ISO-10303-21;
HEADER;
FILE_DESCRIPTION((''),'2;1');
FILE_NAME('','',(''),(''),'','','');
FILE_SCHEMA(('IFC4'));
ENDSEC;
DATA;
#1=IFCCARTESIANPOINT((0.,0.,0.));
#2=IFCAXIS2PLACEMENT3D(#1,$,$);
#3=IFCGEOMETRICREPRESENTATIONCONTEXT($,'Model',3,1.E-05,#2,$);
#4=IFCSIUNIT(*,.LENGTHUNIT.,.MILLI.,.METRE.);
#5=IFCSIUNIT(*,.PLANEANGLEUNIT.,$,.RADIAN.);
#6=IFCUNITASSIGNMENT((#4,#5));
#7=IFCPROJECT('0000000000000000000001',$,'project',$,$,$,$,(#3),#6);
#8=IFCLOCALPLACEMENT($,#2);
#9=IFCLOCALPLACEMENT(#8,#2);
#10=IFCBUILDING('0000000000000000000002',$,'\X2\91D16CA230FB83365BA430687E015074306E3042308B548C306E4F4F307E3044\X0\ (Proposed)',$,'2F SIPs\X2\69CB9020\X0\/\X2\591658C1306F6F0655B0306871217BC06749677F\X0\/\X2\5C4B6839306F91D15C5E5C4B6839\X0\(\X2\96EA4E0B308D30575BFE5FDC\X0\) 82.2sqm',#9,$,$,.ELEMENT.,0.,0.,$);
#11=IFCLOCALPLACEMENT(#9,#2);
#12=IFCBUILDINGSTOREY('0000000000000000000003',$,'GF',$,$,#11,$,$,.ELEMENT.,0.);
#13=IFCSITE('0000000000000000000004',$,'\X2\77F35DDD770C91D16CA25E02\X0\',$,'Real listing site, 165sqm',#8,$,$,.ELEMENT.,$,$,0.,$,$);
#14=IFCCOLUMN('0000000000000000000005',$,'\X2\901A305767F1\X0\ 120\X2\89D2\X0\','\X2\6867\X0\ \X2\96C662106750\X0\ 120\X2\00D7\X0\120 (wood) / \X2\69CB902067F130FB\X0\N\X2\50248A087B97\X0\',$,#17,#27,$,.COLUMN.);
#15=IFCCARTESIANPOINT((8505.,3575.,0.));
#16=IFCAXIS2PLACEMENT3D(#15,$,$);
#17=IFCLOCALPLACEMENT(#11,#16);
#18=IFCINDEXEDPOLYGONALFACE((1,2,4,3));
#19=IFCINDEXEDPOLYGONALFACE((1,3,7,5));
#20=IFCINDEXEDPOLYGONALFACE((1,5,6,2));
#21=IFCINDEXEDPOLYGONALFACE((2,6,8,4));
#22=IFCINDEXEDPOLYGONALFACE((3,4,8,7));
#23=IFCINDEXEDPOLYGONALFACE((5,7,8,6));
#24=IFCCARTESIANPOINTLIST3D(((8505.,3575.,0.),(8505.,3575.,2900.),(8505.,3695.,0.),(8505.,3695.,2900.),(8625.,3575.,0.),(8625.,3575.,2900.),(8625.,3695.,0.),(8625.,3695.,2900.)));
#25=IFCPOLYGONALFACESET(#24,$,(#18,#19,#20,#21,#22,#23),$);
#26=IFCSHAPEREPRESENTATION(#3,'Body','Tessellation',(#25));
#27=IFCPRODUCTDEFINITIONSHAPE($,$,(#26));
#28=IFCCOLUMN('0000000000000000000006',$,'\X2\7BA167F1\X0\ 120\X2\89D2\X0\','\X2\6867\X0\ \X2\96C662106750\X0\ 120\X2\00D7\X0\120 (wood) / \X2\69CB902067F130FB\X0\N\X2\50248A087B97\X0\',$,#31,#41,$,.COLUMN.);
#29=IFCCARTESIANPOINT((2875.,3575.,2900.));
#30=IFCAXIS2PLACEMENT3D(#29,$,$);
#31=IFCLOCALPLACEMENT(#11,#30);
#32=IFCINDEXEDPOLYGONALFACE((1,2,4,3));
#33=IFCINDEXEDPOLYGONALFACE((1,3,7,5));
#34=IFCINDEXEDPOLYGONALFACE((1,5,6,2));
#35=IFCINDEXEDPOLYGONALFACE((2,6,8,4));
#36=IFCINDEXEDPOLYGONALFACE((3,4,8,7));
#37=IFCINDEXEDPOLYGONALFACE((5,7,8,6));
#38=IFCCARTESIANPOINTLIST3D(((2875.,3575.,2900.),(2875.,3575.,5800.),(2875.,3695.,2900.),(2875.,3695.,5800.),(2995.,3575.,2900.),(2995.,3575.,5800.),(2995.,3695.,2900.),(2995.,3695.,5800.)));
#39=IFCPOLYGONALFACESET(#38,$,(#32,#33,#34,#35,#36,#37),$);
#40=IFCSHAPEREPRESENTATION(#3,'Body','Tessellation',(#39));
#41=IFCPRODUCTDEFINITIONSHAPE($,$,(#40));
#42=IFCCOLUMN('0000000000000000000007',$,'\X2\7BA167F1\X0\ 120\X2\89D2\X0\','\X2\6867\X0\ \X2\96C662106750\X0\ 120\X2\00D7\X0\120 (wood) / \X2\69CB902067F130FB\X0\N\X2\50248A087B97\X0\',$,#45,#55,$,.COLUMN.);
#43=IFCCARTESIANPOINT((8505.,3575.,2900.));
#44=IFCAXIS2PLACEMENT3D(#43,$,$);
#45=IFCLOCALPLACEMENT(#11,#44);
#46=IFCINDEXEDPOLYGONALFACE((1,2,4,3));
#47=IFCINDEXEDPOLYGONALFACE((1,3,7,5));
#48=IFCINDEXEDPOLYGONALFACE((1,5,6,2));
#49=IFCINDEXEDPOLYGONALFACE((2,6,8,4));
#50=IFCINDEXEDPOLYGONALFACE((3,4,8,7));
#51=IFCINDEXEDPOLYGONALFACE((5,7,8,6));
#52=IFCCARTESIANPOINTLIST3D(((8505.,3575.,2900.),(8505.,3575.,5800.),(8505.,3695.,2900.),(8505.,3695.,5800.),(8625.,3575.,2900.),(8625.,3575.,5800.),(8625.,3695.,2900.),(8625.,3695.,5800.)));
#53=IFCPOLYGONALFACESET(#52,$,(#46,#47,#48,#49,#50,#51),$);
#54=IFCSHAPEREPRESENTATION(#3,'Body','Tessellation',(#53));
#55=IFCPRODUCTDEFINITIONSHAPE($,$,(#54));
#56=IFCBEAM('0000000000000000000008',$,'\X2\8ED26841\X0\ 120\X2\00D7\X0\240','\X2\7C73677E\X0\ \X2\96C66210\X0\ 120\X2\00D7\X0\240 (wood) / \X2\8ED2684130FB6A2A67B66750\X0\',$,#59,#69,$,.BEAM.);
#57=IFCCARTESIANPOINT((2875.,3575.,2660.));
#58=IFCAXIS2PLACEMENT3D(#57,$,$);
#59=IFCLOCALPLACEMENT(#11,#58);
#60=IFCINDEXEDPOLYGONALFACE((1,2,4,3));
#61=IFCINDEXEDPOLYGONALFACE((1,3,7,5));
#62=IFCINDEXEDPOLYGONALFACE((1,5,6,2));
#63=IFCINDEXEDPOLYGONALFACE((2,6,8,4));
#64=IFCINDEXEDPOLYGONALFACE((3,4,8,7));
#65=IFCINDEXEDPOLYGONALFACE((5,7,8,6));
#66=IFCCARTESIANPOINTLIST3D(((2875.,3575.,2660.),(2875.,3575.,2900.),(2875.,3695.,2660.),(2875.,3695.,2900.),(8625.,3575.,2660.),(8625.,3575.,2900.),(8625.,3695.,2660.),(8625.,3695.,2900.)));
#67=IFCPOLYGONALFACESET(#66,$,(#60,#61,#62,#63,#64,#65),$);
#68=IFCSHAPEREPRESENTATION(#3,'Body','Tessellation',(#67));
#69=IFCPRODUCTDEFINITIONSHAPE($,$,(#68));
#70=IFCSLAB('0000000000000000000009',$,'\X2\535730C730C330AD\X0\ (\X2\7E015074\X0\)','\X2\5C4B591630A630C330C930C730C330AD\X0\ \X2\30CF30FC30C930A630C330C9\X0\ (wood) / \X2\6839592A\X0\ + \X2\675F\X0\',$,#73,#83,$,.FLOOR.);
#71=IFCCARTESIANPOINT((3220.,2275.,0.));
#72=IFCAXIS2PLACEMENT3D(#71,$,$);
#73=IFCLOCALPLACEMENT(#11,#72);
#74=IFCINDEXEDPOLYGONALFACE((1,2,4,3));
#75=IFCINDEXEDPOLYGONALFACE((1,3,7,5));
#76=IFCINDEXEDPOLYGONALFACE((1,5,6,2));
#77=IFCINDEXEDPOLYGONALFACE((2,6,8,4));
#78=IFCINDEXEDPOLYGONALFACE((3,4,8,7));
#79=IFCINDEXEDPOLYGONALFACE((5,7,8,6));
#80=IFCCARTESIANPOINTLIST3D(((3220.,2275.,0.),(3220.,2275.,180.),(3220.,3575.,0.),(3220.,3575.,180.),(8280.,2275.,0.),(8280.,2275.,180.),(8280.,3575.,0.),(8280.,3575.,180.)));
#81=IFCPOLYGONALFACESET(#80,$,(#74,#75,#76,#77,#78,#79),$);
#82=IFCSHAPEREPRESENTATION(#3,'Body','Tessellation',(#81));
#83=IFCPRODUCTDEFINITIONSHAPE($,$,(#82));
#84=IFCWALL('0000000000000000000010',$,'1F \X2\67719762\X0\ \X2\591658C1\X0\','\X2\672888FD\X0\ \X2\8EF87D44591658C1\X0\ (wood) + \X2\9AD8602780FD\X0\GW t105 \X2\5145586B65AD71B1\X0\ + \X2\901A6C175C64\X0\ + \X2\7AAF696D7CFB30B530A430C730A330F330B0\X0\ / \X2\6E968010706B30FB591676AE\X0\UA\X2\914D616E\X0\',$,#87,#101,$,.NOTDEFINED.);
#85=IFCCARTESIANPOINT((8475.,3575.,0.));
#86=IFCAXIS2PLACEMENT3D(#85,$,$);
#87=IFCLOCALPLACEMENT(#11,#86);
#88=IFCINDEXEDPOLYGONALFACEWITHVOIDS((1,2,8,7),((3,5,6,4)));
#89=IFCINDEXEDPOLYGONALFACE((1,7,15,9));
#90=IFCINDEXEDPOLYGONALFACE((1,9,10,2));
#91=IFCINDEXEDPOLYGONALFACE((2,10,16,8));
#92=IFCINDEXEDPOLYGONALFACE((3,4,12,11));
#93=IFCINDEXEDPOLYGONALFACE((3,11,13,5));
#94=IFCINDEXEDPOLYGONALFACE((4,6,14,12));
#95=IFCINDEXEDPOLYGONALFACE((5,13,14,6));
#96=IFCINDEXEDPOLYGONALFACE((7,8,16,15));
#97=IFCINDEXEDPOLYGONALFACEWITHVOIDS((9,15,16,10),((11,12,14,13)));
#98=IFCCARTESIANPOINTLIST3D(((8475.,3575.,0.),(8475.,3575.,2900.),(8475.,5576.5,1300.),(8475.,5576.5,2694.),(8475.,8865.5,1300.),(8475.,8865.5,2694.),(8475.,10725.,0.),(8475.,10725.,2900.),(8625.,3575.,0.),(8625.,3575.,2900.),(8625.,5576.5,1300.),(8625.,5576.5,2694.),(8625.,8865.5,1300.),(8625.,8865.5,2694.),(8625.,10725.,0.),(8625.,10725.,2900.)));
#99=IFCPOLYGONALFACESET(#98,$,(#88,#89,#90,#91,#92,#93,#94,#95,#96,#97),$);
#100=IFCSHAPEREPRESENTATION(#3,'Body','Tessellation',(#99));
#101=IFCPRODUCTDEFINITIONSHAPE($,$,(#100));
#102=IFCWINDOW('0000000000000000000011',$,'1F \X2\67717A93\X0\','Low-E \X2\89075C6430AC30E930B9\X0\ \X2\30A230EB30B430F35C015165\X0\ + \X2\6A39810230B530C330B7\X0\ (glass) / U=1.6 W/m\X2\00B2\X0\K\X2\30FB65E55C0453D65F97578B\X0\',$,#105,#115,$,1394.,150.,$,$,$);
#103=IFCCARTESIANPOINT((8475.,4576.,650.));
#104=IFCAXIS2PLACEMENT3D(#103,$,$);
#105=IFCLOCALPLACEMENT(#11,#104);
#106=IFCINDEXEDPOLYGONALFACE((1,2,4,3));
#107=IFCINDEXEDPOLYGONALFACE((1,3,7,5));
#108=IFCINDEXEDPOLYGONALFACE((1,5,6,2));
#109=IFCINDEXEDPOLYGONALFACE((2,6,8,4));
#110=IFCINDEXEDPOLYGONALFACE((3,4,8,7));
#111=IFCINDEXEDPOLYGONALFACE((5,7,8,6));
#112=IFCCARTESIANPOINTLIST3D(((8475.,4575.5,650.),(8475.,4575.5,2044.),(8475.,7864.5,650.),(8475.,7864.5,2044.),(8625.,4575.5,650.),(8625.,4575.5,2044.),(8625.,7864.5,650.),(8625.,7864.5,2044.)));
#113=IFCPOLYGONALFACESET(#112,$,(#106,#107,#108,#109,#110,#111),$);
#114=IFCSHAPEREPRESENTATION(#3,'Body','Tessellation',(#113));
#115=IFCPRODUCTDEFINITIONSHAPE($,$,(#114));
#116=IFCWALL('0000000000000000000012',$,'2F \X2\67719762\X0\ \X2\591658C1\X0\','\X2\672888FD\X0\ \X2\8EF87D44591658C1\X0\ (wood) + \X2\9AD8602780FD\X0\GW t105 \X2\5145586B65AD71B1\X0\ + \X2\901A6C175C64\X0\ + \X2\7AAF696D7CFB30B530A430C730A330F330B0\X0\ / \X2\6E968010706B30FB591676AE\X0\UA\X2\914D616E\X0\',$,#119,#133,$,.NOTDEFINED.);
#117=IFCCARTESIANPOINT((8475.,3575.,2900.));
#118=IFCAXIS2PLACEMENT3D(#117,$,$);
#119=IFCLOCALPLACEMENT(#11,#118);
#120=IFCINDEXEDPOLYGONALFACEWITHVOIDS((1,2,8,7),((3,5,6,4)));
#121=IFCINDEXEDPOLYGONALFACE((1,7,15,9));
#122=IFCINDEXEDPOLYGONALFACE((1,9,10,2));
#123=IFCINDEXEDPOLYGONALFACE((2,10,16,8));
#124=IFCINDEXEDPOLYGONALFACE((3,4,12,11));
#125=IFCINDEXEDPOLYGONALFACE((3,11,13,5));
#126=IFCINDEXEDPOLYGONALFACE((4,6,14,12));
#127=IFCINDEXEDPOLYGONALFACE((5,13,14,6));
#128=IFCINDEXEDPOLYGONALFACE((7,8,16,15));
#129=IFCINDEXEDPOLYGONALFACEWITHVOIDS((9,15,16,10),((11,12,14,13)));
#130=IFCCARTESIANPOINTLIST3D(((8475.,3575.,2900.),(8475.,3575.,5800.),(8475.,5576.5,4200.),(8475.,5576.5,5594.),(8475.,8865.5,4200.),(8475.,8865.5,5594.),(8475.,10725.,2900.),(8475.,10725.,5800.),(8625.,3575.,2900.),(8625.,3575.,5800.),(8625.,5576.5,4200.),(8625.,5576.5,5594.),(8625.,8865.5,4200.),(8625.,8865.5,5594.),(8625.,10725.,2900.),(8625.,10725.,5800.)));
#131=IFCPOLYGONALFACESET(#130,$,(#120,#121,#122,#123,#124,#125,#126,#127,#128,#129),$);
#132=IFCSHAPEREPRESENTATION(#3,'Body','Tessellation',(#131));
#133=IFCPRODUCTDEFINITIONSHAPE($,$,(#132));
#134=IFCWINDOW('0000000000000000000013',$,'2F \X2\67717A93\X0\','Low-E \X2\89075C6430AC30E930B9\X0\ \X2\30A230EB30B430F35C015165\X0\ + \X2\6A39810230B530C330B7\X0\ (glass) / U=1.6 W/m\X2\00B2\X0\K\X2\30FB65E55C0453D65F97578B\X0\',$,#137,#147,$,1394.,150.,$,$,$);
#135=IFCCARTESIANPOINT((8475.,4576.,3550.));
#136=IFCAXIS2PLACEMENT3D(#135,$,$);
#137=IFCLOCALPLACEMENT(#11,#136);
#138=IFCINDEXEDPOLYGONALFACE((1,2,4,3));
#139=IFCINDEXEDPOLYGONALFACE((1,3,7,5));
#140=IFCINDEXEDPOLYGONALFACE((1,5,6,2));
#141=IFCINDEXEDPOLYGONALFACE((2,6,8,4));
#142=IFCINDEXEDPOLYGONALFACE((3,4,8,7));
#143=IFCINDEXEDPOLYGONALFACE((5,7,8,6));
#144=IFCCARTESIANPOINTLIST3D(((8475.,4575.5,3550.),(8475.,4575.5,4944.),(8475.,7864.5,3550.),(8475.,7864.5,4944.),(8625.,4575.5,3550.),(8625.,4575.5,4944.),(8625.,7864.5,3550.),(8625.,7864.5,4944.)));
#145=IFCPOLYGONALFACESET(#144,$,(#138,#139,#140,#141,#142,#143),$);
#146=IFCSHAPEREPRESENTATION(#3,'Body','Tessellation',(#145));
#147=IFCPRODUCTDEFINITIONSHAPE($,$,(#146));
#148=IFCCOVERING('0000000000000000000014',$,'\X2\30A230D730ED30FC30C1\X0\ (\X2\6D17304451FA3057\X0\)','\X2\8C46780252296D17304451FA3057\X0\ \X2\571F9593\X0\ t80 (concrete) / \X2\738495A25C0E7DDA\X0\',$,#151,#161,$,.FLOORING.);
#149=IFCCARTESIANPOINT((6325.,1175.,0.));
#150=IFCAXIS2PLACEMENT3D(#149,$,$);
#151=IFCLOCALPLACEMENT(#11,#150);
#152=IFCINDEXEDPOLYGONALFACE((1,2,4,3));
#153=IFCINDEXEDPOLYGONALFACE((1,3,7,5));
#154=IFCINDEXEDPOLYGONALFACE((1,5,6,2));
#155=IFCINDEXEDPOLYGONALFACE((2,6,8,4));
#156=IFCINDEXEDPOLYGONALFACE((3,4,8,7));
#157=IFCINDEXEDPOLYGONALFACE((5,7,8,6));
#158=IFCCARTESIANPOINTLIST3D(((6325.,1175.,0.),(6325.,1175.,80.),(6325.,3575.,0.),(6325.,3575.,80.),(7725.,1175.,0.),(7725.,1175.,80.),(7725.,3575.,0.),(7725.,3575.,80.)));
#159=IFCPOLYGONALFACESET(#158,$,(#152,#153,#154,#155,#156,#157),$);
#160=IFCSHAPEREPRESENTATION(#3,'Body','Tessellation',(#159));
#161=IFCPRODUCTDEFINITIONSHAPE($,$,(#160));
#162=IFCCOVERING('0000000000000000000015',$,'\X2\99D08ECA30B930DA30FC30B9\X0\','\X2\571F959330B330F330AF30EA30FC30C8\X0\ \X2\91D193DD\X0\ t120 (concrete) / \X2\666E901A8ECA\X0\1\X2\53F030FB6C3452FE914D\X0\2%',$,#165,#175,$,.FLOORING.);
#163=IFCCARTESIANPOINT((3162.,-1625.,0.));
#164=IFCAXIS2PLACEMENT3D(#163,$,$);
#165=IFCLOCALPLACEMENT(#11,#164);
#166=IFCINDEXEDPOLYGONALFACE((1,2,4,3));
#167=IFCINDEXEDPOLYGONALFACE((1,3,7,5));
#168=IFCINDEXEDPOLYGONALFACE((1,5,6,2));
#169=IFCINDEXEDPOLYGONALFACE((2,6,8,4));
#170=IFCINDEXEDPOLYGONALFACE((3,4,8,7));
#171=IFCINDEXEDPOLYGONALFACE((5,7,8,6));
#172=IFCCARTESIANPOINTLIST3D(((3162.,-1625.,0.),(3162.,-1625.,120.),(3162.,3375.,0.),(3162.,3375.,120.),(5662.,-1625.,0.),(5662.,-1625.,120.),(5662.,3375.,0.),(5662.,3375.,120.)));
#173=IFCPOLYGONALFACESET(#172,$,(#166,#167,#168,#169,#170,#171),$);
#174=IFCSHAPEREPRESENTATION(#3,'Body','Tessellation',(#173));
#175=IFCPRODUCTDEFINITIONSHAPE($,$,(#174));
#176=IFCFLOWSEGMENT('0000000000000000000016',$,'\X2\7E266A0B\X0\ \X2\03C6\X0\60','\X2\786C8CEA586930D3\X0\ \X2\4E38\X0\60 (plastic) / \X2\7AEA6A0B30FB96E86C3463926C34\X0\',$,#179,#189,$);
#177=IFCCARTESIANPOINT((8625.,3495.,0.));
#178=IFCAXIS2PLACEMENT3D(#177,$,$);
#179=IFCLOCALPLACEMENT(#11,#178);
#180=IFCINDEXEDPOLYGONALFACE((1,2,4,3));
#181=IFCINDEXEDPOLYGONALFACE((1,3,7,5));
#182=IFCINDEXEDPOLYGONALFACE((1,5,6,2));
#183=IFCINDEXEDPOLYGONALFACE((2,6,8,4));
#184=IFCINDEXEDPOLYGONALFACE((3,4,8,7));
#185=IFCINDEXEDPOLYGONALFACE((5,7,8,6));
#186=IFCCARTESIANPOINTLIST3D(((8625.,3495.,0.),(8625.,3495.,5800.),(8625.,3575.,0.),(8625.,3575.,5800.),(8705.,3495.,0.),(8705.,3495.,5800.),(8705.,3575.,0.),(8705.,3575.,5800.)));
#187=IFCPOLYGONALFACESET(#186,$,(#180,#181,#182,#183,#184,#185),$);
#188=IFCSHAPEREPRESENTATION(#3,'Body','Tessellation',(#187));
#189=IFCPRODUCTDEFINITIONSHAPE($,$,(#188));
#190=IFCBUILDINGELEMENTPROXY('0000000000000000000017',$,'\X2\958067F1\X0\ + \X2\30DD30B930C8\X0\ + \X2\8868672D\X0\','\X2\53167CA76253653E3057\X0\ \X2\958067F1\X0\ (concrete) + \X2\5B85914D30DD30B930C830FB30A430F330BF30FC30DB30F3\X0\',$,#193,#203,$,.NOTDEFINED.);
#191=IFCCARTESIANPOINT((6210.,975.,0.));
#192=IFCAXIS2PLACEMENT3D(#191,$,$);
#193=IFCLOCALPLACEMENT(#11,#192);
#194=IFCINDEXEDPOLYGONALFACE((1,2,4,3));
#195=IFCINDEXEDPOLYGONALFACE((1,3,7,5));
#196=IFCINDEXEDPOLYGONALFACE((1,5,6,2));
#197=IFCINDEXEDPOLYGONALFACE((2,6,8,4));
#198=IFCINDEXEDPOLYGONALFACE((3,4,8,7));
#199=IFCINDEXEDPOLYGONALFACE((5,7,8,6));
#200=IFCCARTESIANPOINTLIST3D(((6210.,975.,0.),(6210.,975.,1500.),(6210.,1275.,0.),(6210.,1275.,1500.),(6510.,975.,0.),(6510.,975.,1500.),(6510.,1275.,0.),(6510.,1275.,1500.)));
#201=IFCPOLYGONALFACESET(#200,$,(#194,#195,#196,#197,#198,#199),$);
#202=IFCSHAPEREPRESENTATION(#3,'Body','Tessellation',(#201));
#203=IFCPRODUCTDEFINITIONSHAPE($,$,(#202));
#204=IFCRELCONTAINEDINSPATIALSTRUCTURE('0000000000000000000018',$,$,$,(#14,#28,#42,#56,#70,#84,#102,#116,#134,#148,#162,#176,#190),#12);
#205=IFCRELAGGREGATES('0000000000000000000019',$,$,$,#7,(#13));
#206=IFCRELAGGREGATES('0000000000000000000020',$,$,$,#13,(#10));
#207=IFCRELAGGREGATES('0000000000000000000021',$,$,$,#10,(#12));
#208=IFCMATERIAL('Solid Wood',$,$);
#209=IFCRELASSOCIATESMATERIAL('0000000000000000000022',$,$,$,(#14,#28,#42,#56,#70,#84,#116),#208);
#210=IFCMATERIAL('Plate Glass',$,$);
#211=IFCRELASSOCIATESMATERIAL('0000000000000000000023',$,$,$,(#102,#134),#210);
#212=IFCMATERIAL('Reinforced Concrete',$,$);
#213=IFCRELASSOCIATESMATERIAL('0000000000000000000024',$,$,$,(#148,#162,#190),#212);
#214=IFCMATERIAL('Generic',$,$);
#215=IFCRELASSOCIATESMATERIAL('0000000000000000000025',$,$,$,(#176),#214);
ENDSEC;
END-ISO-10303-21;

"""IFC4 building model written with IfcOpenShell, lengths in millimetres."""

from ifc_helpers import new_model, si_unit, frame, frame_2d, origin, place, context, project, spatial, rectangle, extrude, material, element, fill, save


model = new_model("IFC4")

# Units and contexts
model_context = context("Model", 3, precision=1e-05, world=origin())
ifc_project = project(units=[si_unit("LENGTHUNIT", "METRE", prefix="MILLI"), si_unit("PLANEANGLEUNIT", "RADIAN")], contexts=[model_context])

# Site, building, storey
site_placement = place(None, origin())
site = spatial("IfcSite", under=ifc_project, at=site_placement, Name="石川県金沢市", ObjectType="Real listing site, 165sqm", CompositionType="ELEMENT", RefElevation=0.0)
building_placement = place(site_placement, origin())
building = spatial("IfcBuilding", under=site, at=building_placement, Name="金沢・茶室と縁側のある和の住まい (Proposed)", ObjectType="2F SIPs構造/外壁は漆喰と無節杉板/屋根は金属屋根(雪下ろし対応) 82.2sqm", CompositionType="ELEMENT", ElevationOfRefHeight=0.0, ElevationOfTerrain=0.0)
storey_placement = place(building_placement, origin())
storey = spatial("IfcBuildingStorey", under=building, at=storey_placement, Name="GF", CompositionType="ELEMENT", Elevation=0.0)

# Columns
ifc_material_1 = material(Name="Solid Wood")
column_1_placement = place(storey_placement, frame((8505.0, 3575.0, 0.0)))
element("IfcColumn", 1, at=column_1_placement, inside=storey, material=ifc_material_1, Name="通し柱 120角", Description="桧 集成材 120×120 (wood) / 構造柱・N値計算", PredefinedType="COLUMN", context=model_context, shape_type="SweptSolid", body=[
    extrude(rectangle(XDim=120.0, YDim=120.0, at=frame_2d((60.0, 60.0))), frame((8505.0, 3575.0, 0.0)), (0.0, 0.0, 1.0), 2900.0),
])
column_2_placement = place(storey_placement, frame((2875.0, 3575.0, 2900.0)))
element("IfcColumn", 2, at=column_2_placement, inside=storey, material=ifc_material_1, Name="管柱 120角", Description="桧 集成材 120×120 (wood) / 構造柱・N値計算", PredefinedType="COLUMN", context=model_context, shape_type="SweptSolid", body=[
    extrude(rectangle(XDim=120.0, YDim=120.0, at=frame_2d((60.0, 60.0))), frame((2875.0, 3575.0, 2900.0)), (0.0, 0.0, 1.0), 2900.0),
])
column_3_placement = place(storey_placement, frame((8505.0, 3575.0, 2900.0)))
element("IfcColumn", 3, at=column_3_placement, inside=storey, material=ifc_material_1, Name="管柱 120角", Description="桧 集成材 120×120 (wood) / 構造柱・N値計算", PredefinedType="COLUMN", context=model_context, shape_type="SweptSolid", body=[
    extrude(rectangle(XDim=120.0, YDim=120.0, at=frame_2d((60.0, 60.0))), frame((8505.0, 3575.0, 2900.0)), (0.0, 0.0, 1.0), 2900.0),
])

# Beam
beam_1_placement = place(storey_placement, frame((2875.0, 3575.0, 2660.0)))
element("IfcBeam", 4, at=beam_1_placement, inside=storey, material=ifc_material_1, Name="軒桁 120×240", Description="米松 集成 120×240 (wood) / 軒桁・横架材", PredefinedType="BEAM", context=model_context, shape_type="SweptSolid", body=[
    extrude(rectangle(XDim=5750.0, YDim=120.0, at=frame_2d((2875.0, 60.0))), frame((2875.0, 3575.0, 2660.0)), (0.0, 0.0, 1.0), 240.0),
])

# Slab
slab_placement = place(storey_placement, frame((3220.0, 2275.0, 0.0)))
element("IfcSlab", 5, at=slab_placement, inside=storey, material=ifc_material_1, Name="南デッキ (縁側)", Description="屋外ウッドデッキ ハードウッド (wood) / 根太 + 束", PredefinedType="FLOOR", context=model_context, shape_type="SweptSolid", body=[
    extrude(rectangle(XDim=5060.0, YDim=1300.0, at=frame_2d((2530.0, 650.0))), frame((3220.0, 2275.0, 0.0)), (0.0, 0.0, 1.0), 180.0),
])

# Walls, openings, windows
wall_1_placement = place(storey_placement, frame((8475.0, 3575.0, 0.0)))
wall_1 = element("IfcWall", 6, at=wall_1_placement, inside=storey, material=ifc_material_1, Name="1F 東面 外壁", Description="木製 軸組外壁 (wood) + 高性能GW t105 充填断熱 + 通気層 + 窯業系サイディング / 準耐火・外皮UA配慮", PredefinedType="NOTDEFINED", context=model_context, shape_type="SweptSolid", body=[
    extrude(rectangle(XDim=150.0, YDim=7150.0, at=frame_2d((75.0, 3575.0))), frame((8475.0, 3575.0, 0.0)), (0.0, 0.0, 1.0), 2900.0),
])
opening_1_placement = place(storey_placement, frame((8475.0, 4576.0, 650.0)))
opening_1 = element("IfcOpeningElement", 7, at=opening_1_placement, cuts=wall_1, PredefinedType="NOTDEFINED", context=model_context, shape_type="SweptSolid", body=[
    extrude(rectangle(XDim=150.0, YDim=3289.0, at=frame_2d((75.0, 1644.0))), frame((8475.0, 4576.0, 650.0)), (0.0, 0.0, 1.0), 1394.0),
])
ifc_material_2 = material(Name="Plate Glass")
window_1_placement = place(storey_placement, frame((8475.0, 4576.0, 650.0)))
window_1 = element("IfcWindow", 8, at=window_1_placement, inside=storey, material=ifc_material_2, Name="1F 東窓", Description="Low-E 複層ガラス アルゴン封入 + 樹脂サッシ (glass) / U=1.6 W/m²K・日射取得型", OverallHeight=1394.0, OverallWidth=150.0, context=model_context, shape_type="SweptSolid", body=[
    extrude(rectangle(XDim=150.0, YDim=3289.0, at=frame_2d((75.0, 1644.0))), frame((8475.0, 4576.0, 650.0)), (0.0, 0.0, 1.0), 1394.0),
])
fill(opening_1, window_1)
wall_2_placement = place(storey_placement, frame((8475.0, 3575.0, 2900.0)))
wall_2 = element("IfcWall", 9, at=wall_2_placement, inside=storey, material=ifc_material_1, Name="2F 東面 外壁", Description="木製 軸組外壁 (wood) + 高性能GW t105 充填断熱 + 通気層 + 窯業系サイディング / 準耐火・外皮UA配慮", PredefinedType="NOTDEFINED", context=model_context, shape_type="SweptSolid", body=[
    extrude(rectangle(XDim=150.0, YDim=7150.0, at=frame_2d((75.0, 3575.0))), frame((8475.0, 3575.0, 2900.0)), (0.0, 0.0, 1.0), 2900.0),
])
opening_2_placement = place(storey_placement, frame((8475.0, 4576.0, 3550.0)))
opening_2 = element("IfcOpeningElement", 10, at=opening_2_placement, cuts=wall_2, PredefinedType="NOTDEFINED", context=model_context, shape_type="SweptSolid", body=[
    extrude(rectangle(XDim=150.0, YDim=3289.0, at=frame_2d((75.0, 1644.0))), frame((8475.0, 4576.0, 3550.0)), (0.0, 0.0, 1.0), 1394.0),
])
window_2_placement = place(storey_placement, frame((8475.0, 4576.0, 3550.0)))
window_2 = element("IfcWindow", 11, at=window_2_placement, inside=storey, material=ifc_material_2, Name="2F 東窓", Description="Low-E 複層ガラス アルゴン封入 + 樹脂サッシ (glass) / U=1.6 W/m²K・日射取得型", OverallHeight=1394.0, OverallWidth=150.0, context=model_context, shape_type="SweptSolid", body=[
    extrude(rectangle(XDim=150.0, YDim=3289.0, at=frame_2d((75.0, 1644.0))), frame((8475.0, 4576.0, 3550.0)), (0.0, 0.0, 1.0), 1394.0),
])
fill(opening_2, window_2)

# Coverings
ifc_material_3 = material(Name="Reinforced Concrete")
covering_1_placement = place(storey_placement, frame((6325.0, 1175.0, 0.0)))
element("IfcCovering", 12, at=covering_1_placement, inside=storey, material=ifc_material_3, Name="アプローチ (洗い出し)", Description="豆砂利洗い出し 土間 t80 (concrete) / 玄関導線", PredefinedType="FLOORING", context=model_context, shape_type="SweptSolid", body=[
    extrude(rectangle(XDim=1400.0, YDim=2400.0, at=frame_2d((700.0, 1200.0))), frame((6325.0, 1175.0, 0.0)), (0.0, 0.0, 1.0), 80.0),
])
covering_2_placement = place(storey_placement, frame((3162.0, -1625.0, 0.0)))
element("IfcCovering", 13, at=covering_2_placement, inside=storey, material=ifc_material_3, Name="駐車スペース", Description="土間コンクリート 金鏝 t120 (concrete) / 普通車1台・水勾配2%", PredefinedType="FLOORING", context=model_context, shape_type="SweptSolid", body=[
    extrude(rectangle(XDim=2500.0, YDim=5000.0, at=frame_2d((1250.0, 2500.0))), frame((3162.0, -1625.0, 0.0)), (0.0, 0.0, 1.0), 120.0),
])

# Flow segment
ifc_material_4 = material(Name="Generic")
flow_segment_placement = place(storey_placement, frame((8625.0, 3495.0, 0.0)))
element("IfcFlowSegment", 14, at=flow_segment_placement, inside=storey, material=ifc_material_4, Name="縦樋 φ60", Description="硬質塩ビ 丸60 (plastic) / 竪樋・雨水排水", context=model_context, shape_type="SweptSolid", body=[
    extrude(rectangle(XDim=80.0, YDim=80.0, at=frame_2d((40.0, 40.0))), frame((8625.0, 3495.0, 0.0)), (0.0, 0.0, 1.0), 5800.0),
])

# Building element proxy
proxy_placement = place(storey_placement, frame((6210.0, 975.0, 0.0)))
element("IfcBuildingElementProxy", 15, at=proxy_placement, inside=storey, material=ifc_material_3, Name="門柱 + ポスト + 表札", Description="化粧打放し 門柱 (concrete) + 宅配ポスト・インターホン", PredefinedType="NOTDEFINED", context=model_context, shape_type="SweptSolid", body=[
    extrude(rectangle(XDim=300.0, YDim=300.0, at=frame_2d((150.0, 150.0))), frame((6210.0, 975.0, 0.0)), (0.0, 0.0, 1.0), 1500.0),
])

save(model, "model.ifc")
